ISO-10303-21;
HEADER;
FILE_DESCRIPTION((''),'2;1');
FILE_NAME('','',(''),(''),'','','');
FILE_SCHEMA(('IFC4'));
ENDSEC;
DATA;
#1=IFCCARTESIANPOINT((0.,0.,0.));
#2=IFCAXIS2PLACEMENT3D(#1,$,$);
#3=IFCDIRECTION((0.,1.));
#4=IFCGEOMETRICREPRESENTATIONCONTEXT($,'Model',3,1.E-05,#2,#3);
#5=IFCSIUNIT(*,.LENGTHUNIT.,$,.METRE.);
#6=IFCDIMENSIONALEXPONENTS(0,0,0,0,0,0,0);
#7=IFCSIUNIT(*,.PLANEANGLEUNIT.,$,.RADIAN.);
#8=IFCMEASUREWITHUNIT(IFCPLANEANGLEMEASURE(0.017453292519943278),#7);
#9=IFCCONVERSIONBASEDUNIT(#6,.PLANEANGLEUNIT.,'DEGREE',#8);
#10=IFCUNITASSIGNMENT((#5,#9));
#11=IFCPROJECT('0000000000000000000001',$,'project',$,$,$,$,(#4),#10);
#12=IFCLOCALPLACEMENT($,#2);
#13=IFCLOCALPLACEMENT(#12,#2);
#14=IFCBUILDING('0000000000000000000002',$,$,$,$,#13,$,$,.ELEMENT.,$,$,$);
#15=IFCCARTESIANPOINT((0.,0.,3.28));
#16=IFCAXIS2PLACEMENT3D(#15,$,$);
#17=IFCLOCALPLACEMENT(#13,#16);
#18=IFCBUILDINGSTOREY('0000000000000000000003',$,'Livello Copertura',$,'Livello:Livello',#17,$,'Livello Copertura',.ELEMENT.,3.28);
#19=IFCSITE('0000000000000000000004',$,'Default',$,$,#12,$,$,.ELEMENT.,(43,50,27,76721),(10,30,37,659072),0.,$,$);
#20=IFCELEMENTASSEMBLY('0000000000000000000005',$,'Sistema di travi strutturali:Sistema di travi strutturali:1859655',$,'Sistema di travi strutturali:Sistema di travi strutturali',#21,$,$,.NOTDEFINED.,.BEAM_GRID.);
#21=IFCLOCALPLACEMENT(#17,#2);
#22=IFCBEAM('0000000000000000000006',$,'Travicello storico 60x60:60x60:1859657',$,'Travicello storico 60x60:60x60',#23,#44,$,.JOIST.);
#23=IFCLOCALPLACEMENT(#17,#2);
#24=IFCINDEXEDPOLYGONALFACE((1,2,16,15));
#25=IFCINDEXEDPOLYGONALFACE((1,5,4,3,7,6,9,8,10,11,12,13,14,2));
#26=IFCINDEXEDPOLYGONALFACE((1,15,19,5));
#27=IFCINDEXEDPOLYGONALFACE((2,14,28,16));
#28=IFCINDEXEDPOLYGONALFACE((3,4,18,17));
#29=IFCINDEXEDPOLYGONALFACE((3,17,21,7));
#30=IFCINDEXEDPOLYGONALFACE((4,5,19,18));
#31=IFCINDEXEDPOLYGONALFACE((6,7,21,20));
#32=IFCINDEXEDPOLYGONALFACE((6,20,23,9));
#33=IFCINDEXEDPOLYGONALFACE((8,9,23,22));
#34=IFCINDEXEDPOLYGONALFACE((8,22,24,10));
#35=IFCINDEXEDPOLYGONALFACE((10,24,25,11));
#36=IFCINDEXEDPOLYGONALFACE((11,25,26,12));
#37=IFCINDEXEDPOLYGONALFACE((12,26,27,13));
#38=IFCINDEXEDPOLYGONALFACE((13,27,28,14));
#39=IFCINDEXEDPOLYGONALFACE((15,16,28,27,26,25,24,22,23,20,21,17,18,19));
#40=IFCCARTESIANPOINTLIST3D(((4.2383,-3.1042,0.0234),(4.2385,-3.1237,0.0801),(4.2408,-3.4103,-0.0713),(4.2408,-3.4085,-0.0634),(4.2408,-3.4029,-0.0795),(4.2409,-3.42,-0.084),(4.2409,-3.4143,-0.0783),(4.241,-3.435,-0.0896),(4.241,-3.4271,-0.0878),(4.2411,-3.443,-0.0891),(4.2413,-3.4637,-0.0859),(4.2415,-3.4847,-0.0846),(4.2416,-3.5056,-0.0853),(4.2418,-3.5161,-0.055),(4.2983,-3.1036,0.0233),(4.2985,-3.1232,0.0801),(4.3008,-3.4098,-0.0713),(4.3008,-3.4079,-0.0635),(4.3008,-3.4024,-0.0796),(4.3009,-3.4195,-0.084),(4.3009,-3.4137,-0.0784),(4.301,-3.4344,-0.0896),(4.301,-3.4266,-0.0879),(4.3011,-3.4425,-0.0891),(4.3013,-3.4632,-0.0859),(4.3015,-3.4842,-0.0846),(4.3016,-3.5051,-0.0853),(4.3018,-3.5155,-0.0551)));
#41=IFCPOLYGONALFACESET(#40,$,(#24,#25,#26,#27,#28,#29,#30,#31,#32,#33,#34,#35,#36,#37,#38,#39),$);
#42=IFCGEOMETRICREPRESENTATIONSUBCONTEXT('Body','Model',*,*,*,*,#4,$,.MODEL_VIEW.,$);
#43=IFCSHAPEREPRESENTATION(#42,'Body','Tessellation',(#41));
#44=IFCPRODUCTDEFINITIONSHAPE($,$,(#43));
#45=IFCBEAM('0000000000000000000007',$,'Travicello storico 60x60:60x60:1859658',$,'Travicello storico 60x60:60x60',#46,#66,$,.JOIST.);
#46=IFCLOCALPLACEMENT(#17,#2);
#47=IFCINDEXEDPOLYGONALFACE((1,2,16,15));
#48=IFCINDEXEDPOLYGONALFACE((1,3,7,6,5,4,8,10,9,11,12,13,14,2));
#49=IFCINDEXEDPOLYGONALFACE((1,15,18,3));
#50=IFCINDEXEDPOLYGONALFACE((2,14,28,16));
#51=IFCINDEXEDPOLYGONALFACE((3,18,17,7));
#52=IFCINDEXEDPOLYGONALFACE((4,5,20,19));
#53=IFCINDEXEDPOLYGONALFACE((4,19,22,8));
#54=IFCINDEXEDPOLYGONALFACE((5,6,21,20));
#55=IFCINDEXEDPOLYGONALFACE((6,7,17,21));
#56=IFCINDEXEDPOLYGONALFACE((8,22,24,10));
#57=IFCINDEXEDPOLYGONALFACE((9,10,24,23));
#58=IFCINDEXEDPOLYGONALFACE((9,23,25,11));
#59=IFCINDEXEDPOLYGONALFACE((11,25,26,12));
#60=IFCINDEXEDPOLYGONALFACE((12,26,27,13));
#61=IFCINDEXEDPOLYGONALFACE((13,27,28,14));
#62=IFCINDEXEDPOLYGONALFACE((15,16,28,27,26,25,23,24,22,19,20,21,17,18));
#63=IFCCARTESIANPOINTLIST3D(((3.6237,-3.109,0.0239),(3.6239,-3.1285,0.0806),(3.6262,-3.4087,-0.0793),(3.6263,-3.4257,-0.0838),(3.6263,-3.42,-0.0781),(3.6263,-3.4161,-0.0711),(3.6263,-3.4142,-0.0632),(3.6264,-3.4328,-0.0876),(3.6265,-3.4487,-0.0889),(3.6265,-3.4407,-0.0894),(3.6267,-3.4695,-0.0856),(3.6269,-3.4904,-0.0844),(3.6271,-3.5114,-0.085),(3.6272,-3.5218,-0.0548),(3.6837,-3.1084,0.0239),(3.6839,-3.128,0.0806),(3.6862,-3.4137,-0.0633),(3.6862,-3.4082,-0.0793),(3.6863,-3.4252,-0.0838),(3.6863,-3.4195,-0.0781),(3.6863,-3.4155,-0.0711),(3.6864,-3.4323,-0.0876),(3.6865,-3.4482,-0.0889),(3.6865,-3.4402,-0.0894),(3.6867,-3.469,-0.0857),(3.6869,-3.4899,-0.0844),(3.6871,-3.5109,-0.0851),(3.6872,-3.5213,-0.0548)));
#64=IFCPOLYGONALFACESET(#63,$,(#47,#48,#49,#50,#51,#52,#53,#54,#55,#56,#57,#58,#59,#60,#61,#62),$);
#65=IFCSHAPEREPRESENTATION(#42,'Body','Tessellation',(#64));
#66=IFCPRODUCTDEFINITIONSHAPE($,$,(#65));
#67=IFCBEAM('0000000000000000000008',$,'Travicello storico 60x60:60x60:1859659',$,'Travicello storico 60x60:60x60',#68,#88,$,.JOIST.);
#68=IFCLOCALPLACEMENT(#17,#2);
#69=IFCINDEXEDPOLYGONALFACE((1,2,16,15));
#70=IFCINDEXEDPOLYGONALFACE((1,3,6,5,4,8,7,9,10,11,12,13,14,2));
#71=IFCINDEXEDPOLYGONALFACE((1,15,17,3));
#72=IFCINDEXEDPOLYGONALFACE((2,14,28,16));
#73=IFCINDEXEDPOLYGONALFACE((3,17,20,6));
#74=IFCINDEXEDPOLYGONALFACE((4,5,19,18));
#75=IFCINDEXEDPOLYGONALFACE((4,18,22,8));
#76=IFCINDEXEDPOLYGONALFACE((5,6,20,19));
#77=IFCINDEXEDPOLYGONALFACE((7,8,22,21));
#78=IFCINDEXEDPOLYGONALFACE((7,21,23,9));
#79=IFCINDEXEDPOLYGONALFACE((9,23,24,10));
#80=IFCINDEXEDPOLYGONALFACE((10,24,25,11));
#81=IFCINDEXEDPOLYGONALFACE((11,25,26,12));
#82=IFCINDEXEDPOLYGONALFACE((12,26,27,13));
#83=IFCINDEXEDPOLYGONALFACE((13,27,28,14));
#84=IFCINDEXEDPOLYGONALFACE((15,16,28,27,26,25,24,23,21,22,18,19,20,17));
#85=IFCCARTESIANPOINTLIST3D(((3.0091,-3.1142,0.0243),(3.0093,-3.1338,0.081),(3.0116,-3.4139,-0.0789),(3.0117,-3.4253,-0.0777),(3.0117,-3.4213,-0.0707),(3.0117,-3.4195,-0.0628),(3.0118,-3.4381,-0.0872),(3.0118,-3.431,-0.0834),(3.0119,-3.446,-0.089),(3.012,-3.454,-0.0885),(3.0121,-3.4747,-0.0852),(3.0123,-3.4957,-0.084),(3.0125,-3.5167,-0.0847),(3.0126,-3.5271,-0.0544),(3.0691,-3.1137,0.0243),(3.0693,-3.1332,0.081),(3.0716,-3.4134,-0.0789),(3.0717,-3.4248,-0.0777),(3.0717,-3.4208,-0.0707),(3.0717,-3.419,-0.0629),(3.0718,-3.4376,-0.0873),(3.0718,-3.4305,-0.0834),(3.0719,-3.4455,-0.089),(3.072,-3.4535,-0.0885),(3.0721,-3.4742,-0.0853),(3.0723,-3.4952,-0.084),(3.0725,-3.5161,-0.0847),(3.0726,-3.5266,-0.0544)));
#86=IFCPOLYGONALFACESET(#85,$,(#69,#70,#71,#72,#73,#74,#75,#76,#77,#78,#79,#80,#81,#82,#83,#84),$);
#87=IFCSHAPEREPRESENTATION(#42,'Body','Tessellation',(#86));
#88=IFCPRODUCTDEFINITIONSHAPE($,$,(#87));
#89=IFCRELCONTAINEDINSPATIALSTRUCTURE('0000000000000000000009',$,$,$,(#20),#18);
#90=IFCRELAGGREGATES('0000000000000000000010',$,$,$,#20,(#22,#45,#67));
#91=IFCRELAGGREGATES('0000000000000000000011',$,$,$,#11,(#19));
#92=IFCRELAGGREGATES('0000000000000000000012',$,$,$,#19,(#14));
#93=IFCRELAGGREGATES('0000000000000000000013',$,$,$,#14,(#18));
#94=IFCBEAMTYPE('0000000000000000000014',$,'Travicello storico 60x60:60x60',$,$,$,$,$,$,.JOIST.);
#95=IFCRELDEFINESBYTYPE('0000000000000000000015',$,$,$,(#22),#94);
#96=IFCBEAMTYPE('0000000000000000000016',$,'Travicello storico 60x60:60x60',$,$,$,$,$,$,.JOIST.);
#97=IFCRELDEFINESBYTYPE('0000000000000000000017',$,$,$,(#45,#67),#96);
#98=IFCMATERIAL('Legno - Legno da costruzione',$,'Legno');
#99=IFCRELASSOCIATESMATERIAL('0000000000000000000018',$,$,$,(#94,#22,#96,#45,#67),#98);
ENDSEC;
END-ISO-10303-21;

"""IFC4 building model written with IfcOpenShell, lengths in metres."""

from ifc_helpers import new_model, entity, si_unit, converted_unit, direction, frame, origin, place, context, subcontext, project, spatial, line, arc, indexed_curve, outline, extrude, source, transform, mapped, material, type_object, type_shapes, element, aggregate, save


model = new_model("IFC4")

# Units and contexts
model_context = context("Model", 3, precision=1e-05, world=origin(), true_north=direction((0.0, 1.0)))
body_context = subcontext(model_context, "Body", "Model", "MODEL_VIEW")
ifc_project = project(units=[si_unit("LENGTHUNIT", "METRE"), converted_unit("PLANEANGLEUNIT", "DEGREE", entity("IfcPlaneAngleMeasure", 0.017453292519943278), si_unit("PLANEANGLEUNIT", "RADIAN"), dimensions=[0, 0, 0, 0, 0, 0, 0])], contexts=[model_context])

# Site, building, storey
site_placement = place(None, origin())
site = spatial("IfcSite", under=ifc_project, at=site_placement, Name="Default", CompositionType="ELEMENT", RefLatitude=(43, 50, 27, 76721), RefLongitude=(10, 30, 37, 659072), RefElevation=0.0)
building_placement = place(site_placement, origin())
building = spatial("IfcBuilding", under=site, at=building_placement, CompositionType="ELEMENT")
storey_placement = place(building_placement, frame((0.0, 0.0, 3.28)))
storey = spatial("IfcBuildingStorey", under=building, at=storey_placement, Name="Livello Copertura", ObjectType="Livello:Livello", LongName="Livello Copertura", CompositionType="ELEMENT", Elevation=3.28)

# Element assembly, beams
ifc_material = material(Name="Legno - Legno da costruzione", Category="Legno")
assembly_1_placement = place(storey_placement, origin())
assembly_1 = element("IfcElementAssembly", 1, at=assembly_1_placement, inside=storey, Name="Sistema di travi strutturali:Sistema di travi strutturali:1859655", ObjectType="Sistema di travi strutturali:Sistema di travi strutturali", AssemblyPlace="NOTDEFINED", PredefinedType="BEAM_GRID")
beam_type_1 = type_object("IfcBeamType", Name="Travicello storico 60x60:60x60", PredefinedType="JOIST", material=ifc_material)
shared_shape_1 = source(origin(), body_context, "Body", "SweptSolid", [
    extrude(outline(indexed_curve([(-0.0359, -0.2599), (0.0241, -0.2599), (0.0241, 0.0561), (0.0071, 0.0561), (0.0228, 0.0737), (0.0201, 0.0971), (0.0061, 0.1253), (-0.0039, 0.1551), (-0.0359, 0.1551)], segments=[line(1, 2, 3, 4), arc(4, 5, 6), arc(6, 7, 8), line(8, 9, 1)], self_intersect=False)), frame((0.0876, -0.03, -0.0059), z_axis=(0.0, 1.0, 0.0), x_axis=(0.0, 0.0, -1.0)), (0.0, 0.0, 1.0), 0.06),
])
type_shapes(beam_type_1, [shared_shape_1])
beam_1_placement = place(assembly_1_placement, frame((4.2711, -3.4422, -0.0614), z_axis=(0.003393, -0.32555, 0.945519), x_axis=(-0.007932, 0.945486, 0.325568)))
beam_1 = element("IfcBeam", 2, at=beam_1_placement, type_object=beam_type_1, material=ifc_material, Name="Travicello storico 60x60:60x60:1859657", ObjectType="Travicello storico 60x60:60x60", PredefinedType="JOIST", context=body_context, shape_type="MappedRepresentation", body=[
    mapped(shared_shape_1, transform((0.0, 0.0, 0.0), scale=1.0)),
])
beam_type_2 = type_object("IfcBeamType", Name="Travicello storico 60x60:60x60", PredefinedType="JOIST", material=ifc_material)
shared_shape_2 = source(origin(), body_context, "Body", "SweptSolid", [
    extrude(outline(indexed_curve([(-0.0359, -0.2606), (0.0241, -0.2606), (0.0241, 0.0564), (0.0071, 0.0564), (0.0228, 0.074), (0.0201, 0.0974), (0.0061, 0.1256), (-0.0039, 0.1554), (-0.0359, 0.1554)], segments=[line(1, 2, 3, 4), arc(4, 5, 6), arc(6, 7, 8), line(8, 9, 1)], self_intersect=False)), frame((0.0874, -0.03, -0.0059), z_axis=(0.0, 1.0, 0.0), x_axis=(0.0, 0.0, -1.0)), (0.0, 0.0, 1.0), 0.06),
])
type_shapes(beam_type_2, [shared_shape_2])
beam_2_placement = place(assembly_1_placement, frame((3.6565, -3.4475, -0.061), z_axis=(0.003393, -0.32555, 0.945519), x_axis=(-0.007932, 0.945486, 0.325568)))
beam_2 = element("IfcBeam", 3, at=beam_2_placement, type_object=beam_type_2, material=ifc_material, Name="Travicello storico 60x60:60x60:1859658", ObjectType="Travicello storico 60x60:60x60", PredefinedType="JOIST", context=body_context, shape_type="MappedRepresentation", body=[
    mapped(shared_shape_2, transform((0.0, 0.0, 0.0), scale=1.0)),
])
beam_3_placement = place(assembly_1_placement, frame((3.042, -3.4528, -0.0606), z_axis=(0.003393, -0.32555, 0.945519), x_axis=(-0.007932, 0.945486, 0.325568)))
beam_3 = element("IfcBeam", 4, at=beam_3_placement, type_object=beam_type_2, material=ifc_material, Name="Travicello storico 60x60:60x60:1859659", ObjectType="Travicello storico 60x60:60x60", PredefinedType="JOIST", context=body_context, shape_type="MappedRepresentation", body=[
    mapped(shared_shape_2, transform((0.0, 0.0, 0.0), scale=1.0)),
])
aggregate(assembly_1, [beam_1, beam_2, beam_3])

save(model, "model.ifc")
